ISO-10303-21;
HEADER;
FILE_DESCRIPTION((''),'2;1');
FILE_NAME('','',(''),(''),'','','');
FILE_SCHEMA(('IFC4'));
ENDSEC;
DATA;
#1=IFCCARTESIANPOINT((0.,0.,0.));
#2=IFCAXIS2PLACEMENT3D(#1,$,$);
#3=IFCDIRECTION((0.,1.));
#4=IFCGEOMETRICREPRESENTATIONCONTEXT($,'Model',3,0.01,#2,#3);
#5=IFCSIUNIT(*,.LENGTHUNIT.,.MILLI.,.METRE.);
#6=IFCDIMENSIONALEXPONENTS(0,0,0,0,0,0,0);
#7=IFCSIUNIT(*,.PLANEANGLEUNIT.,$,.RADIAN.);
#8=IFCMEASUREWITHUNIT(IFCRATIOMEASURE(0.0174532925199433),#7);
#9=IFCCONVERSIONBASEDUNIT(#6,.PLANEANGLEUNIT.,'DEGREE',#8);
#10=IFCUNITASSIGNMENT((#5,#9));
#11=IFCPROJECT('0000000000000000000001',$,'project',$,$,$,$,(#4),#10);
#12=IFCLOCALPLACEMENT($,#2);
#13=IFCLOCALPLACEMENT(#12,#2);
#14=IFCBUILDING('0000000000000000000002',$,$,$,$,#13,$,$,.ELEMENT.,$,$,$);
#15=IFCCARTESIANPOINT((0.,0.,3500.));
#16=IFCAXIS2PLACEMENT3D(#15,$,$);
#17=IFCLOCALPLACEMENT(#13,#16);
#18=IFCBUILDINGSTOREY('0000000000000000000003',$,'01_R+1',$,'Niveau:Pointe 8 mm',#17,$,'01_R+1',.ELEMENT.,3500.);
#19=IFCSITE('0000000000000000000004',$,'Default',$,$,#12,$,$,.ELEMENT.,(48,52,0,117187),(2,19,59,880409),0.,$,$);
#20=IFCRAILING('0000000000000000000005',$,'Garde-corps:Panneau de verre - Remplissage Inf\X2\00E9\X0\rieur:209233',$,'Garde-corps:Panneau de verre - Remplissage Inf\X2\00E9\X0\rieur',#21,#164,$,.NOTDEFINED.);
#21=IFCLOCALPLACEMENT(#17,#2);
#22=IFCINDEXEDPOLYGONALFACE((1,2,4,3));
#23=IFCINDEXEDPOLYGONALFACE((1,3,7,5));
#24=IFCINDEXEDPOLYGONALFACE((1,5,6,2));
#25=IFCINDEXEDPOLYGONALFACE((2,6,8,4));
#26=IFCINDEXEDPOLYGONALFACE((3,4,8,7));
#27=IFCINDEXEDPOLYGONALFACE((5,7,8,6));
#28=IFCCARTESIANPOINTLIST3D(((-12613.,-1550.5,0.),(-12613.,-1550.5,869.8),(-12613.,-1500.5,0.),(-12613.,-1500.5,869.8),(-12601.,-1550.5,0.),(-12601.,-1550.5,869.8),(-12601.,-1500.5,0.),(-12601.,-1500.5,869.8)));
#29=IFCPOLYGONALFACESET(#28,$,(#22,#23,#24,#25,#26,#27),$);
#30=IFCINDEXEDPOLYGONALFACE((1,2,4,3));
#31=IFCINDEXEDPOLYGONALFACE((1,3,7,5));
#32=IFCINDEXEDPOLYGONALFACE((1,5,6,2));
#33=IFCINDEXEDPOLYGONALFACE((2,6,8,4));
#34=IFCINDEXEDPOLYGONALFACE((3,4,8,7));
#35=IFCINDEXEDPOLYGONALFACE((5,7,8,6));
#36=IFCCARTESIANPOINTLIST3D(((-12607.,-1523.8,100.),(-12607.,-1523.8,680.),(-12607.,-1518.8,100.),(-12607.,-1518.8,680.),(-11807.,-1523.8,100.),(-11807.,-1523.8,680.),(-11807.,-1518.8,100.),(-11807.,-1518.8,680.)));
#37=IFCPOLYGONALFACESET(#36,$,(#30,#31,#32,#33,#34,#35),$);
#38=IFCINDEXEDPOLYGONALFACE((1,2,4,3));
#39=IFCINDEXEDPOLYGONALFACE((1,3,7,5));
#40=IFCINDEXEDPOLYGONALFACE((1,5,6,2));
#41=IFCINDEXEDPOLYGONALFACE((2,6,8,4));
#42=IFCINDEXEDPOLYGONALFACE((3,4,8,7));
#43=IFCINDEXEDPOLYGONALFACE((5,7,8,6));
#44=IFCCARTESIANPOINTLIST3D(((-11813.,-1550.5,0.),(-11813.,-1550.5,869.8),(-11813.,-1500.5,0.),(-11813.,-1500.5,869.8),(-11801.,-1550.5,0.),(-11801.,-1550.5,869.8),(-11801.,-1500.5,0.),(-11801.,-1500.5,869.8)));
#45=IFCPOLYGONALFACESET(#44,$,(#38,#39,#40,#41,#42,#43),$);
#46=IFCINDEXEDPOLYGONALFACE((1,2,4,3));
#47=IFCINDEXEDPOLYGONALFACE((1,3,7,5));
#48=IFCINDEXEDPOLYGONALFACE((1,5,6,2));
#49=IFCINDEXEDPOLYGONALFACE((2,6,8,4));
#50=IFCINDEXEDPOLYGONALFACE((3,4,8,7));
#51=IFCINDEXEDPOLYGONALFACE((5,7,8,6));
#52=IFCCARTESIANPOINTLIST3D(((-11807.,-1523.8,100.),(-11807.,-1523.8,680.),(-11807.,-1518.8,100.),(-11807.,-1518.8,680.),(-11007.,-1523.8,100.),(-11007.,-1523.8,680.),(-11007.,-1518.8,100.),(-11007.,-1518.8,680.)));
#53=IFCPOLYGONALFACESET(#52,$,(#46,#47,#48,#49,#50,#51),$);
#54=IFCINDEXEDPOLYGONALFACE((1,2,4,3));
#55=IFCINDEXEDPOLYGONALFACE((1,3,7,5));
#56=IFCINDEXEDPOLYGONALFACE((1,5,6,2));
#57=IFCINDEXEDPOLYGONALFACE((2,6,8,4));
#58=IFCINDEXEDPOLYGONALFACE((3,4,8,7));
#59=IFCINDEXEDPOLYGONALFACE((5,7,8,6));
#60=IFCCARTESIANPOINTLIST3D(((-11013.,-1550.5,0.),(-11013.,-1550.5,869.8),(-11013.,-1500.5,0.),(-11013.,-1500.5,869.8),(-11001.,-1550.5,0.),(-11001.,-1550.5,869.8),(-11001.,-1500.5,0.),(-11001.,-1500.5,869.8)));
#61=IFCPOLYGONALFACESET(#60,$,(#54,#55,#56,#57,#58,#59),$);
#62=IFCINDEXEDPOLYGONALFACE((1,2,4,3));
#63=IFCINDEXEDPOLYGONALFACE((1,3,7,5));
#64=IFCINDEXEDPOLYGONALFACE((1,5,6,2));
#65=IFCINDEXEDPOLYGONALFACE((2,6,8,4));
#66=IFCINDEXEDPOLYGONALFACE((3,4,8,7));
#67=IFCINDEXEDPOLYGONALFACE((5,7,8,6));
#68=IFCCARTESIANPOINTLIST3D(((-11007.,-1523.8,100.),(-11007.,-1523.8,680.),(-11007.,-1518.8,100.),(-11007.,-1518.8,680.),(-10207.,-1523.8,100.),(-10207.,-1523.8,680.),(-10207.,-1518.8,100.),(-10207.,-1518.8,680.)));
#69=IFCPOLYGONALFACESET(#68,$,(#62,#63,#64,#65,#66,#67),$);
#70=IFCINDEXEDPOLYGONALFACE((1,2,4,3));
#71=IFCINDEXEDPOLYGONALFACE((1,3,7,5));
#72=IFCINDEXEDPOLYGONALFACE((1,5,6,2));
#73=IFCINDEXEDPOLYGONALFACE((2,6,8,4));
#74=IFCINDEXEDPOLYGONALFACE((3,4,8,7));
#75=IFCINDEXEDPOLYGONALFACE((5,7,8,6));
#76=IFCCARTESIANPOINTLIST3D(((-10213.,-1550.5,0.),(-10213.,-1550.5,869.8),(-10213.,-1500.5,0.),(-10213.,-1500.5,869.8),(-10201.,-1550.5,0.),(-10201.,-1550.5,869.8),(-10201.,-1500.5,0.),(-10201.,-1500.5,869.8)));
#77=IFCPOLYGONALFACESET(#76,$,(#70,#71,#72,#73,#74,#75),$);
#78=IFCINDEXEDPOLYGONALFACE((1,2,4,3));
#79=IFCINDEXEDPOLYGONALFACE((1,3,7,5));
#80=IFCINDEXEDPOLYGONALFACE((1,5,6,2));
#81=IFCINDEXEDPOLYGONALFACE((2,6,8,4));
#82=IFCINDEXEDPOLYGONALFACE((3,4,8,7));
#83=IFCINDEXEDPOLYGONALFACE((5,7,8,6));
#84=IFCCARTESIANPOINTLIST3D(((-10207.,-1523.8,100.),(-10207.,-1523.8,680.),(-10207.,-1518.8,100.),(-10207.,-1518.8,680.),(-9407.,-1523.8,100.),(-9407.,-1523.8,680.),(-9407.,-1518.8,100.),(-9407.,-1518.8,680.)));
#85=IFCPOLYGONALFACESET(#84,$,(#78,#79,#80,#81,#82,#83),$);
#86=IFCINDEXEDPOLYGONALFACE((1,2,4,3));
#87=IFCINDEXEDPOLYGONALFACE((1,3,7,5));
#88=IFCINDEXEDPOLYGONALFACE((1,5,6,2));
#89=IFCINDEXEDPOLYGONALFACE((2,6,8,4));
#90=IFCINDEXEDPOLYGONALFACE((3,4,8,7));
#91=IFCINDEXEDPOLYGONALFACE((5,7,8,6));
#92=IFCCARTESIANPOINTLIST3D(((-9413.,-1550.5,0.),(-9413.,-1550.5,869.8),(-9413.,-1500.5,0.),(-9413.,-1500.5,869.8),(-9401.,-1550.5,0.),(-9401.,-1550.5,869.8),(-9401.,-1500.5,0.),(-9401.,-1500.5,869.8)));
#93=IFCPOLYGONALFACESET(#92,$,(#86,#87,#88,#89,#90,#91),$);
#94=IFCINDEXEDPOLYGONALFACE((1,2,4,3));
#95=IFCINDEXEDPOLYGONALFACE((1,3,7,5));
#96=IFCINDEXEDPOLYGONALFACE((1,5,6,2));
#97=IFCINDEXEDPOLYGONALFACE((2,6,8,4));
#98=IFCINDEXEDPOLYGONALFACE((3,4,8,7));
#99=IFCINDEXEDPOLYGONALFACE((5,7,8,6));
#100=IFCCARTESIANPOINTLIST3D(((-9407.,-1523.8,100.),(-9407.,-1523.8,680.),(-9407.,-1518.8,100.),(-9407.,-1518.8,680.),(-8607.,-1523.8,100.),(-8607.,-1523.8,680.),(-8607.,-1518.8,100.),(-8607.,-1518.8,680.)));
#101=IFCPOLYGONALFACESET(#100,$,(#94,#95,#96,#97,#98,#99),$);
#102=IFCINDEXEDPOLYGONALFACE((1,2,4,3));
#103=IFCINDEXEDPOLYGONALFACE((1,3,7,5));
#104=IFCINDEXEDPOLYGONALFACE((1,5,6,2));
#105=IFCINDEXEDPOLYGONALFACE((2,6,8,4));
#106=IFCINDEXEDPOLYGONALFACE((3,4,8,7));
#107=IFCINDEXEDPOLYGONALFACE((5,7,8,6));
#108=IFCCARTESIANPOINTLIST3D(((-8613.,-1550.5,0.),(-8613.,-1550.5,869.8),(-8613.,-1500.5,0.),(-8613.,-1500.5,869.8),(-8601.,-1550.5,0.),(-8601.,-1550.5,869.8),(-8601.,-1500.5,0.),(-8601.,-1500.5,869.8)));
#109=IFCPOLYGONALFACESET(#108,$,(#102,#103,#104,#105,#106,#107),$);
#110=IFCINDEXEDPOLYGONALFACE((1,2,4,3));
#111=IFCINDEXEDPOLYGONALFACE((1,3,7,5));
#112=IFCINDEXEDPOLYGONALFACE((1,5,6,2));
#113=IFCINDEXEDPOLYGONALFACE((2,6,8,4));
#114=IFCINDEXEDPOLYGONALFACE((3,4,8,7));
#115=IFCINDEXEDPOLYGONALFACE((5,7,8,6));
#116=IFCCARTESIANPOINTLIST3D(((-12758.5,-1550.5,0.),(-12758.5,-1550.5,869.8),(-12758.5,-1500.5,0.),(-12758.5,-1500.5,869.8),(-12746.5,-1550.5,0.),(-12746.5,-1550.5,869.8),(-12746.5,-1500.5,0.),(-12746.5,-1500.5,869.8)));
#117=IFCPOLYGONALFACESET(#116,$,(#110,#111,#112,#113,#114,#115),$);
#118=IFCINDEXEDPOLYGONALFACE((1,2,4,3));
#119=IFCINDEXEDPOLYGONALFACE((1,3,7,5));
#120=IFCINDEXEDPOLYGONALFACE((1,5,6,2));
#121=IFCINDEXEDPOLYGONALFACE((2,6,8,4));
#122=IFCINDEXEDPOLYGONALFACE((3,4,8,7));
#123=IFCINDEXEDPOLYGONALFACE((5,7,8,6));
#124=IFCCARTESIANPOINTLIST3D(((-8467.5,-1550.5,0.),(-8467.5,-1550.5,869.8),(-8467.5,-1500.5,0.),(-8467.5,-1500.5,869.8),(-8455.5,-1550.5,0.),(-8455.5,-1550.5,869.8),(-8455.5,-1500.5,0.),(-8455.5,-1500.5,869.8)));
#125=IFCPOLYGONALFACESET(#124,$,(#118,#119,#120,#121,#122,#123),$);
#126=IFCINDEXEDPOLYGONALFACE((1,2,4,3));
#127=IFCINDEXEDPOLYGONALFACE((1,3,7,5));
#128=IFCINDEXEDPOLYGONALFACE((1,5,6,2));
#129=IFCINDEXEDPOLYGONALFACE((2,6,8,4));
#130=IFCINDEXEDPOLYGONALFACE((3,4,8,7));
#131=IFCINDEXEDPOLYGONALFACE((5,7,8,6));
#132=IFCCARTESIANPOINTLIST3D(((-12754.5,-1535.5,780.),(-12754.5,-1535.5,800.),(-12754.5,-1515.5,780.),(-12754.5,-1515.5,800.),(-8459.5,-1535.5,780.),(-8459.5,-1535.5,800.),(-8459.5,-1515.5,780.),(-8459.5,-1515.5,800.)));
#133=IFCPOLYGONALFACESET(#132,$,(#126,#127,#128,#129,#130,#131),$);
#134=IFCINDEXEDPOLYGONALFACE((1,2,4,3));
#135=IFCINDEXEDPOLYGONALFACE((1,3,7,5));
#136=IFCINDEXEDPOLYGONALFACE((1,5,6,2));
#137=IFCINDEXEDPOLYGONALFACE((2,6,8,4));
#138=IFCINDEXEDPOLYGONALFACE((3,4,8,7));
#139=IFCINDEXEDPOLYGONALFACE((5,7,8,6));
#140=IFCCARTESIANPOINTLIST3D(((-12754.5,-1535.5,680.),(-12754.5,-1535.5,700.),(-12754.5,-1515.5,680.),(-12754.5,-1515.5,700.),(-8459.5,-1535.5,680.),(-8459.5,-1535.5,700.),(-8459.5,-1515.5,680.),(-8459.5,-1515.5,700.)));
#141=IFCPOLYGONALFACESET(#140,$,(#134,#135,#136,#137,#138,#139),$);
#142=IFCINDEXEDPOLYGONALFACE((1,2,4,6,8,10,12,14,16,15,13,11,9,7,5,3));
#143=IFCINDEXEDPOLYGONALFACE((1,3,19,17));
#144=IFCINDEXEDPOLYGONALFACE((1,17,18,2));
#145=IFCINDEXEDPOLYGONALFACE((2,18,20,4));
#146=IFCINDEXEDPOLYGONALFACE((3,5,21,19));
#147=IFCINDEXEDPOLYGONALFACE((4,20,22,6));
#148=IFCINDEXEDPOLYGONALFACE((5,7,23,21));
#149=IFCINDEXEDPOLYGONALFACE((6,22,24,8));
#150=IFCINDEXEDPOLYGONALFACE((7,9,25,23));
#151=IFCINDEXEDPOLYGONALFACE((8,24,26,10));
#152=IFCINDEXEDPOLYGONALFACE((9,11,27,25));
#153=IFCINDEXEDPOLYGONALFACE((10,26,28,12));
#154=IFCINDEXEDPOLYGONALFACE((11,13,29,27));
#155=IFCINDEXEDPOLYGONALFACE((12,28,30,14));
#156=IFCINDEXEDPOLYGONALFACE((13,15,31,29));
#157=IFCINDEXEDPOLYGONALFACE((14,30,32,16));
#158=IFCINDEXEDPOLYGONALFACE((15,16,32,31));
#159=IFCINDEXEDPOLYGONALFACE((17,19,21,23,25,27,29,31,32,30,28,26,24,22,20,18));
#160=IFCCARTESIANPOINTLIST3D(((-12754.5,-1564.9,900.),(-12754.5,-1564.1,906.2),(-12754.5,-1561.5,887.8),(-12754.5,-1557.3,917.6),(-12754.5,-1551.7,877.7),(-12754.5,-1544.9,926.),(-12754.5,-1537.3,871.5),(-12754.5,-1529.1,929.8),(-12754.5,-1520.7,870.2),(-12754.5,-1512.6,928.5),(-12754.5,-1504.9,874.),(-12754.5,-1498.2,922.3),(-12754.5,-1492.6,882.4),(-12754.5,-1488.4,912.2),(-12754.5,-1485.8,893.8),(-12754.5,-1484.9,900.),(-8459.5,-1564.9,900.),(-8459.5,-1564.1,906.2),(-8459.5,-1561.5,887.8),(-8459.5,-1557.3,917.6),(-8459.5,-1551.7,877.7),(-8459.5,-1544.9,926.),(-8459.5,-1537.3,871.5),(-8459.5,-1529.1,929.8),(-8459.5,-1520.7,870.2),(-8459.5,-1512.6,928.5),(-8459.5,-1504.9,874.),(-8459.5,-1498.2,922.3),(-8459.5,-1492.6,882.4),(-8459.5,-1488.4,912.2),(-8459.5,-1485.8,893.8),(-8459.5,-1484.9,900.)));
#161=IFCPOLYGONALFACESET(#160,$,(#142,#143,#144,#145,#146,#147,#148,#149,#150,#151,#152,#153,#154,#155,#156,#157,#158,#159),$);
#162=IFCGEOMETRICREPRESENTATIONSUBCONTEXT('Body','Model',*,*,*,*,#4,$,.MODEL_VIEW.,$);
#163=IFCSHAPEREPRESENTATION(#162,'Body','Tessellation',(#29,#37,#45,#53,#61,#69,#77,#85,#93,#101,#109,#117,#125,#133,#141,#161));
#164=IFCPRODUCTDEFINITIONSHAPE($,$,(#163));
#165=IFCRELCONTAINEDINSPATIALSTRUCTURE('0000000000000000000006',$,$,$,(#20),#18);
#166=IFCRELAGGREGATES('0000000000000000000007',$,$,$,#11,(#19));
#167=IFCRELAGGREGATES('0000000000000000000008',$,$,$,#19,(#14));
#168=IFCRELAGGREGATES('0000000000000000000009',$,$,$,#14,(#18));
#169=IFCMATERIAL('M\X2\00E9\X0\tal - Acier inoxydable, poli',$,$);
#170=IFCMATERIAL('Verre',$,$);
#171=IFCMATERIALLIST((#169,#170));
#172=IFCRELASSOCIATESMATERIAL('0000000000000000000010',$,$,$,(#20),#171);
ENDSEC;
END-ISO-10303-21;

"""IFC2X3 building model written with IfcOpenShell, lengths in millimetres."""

from ifc_helpers import new_model, entity, si_unit, converted_unit, direction, frame, frame_2d, origin, origin_2d_with_axis, place, context, subcontext, project, spatial, polyline, rectangle, outline, extrude, material, material_list, element, save


model = new_model("IFC2X3")

# Units and contexts
model_context = context("Model", 3, precision=0.01, world=origin(), true_north=direction((0.0, 1.0)))
body_context = subcontext(model_context, "Body", "Model", "MODEL_VIEW")
ifc_project = project(units=[si_unit("LENGTHUNIT", "METRE", prefix="MILLI"), converted_unit("PLANEANGLEUNIT", "DEGREE", entity("IfcRatioMeasure", 0.0174532925199433), si_unit("PLANEANGLEUNIT", "RADIAN"), dimensions=[0, 0, 0, 0, 0, 0, 0])], contexts=[model_context])

# Site, building, storey
site_placement = place(None, origin())
site = spatial("IfcSite", under=ifc_project, at=site_placement, Name="Default", CompositionType="ELEMENT", RefLatitude=(48, 52, 0, 117187), RefLongitude=(2, 19, 59, 880409), RefElevation=0.0)
building_placement = place(site_placement, origin())
building = spatial("IfcBuilding", under=site, at=building_placement, CompositionType="ELEMENT")
storey_placement = place(building_placement, frame((0.0, 0.0, 3500.0)))
storey = spatial("IfcBuildingStorey", under=building, at=storey_placement, Name="01_R+1", ObjectType="Niveau:Pointe 8 mm", LongName="01_R+1", CompositionType="ELEMENT", Elevation=3500.0)

# Railing
ifc_material_1 = material(Name="Métal - Acier inoxydable, poli")
ifc_material_2 = material(Name="Verre")
ifc_material_list_1 = material_list([ifc_material_1, ifc_material_2])
railing_1_placement = place(storey_placement, origin())
element("IfcRailing", 1, at=railing_1_placement, inside=storey, material=ifc_material_list_1, Name="Garde-corps:Panneau de verre - Remplissage Inférieur:209233", ObjectType="Garde-corps:Panneau de verre - Remplissage Inférieur", PredefinedType="NOTDEFINED", context=body_context, shape_type="SweptSolid", body=[
    extrude(rectangle(XDim=50.0, YDim=12.0, at=frame_2d((0.0, 0.0), x_axis=(1.0, 0.0))), frame((-12607.0, -1525.5, 0.0), z_axis=(0.0, 0.0, 1.0), x_axis=(0.0, 1.0, 0.0)), (0.0, 0.0, 1.0), 869.8),
    extrude(rectangle(XDim=5.0, YDim=800.0, at=frame_2d((0.0, 0.0), x_axis=(1.0, 0.0))), frame((-12207.0, -1521.3, 100.0), z_axis=(0.0, 0.0, 1.0), x_axis=(0.0, 1.0, 0.0)), (0.0, 0.0, 1.0), 580.0),
    extrude(rectangle(XDim=50.0, YDim=12.0, at=frame_2d((0.0, 0.0), x_axis=(1.0, 0.0))), frame((-11807.0, -1525.5, 0.0), z_axis=(0.0, 0.0, 1.0), x_axis=(0.0, 1.0, 0.0)), (0.0, 0.0, 1.0), 869.8),
    extrude(rectangle(XDim=5.0, YDim=800.0, at=frame_2d((0.0, 0.0), x_axis=(1.0, 0.0))), frame((-11407.0, -1521.3, 100.0), z_axis=(0.0, 0.0, 1.0), x_axis=(0.0, 1.0, 0.0)), (0.0, 0.0, 1.0), 580.0),
    extrude(rectangle(XDim=50.0, YDim=12.0, at=frame_2d((0.0, 0.0), x_axis=(1.0, 0.0))), frame((-11007.0, -1525.5, 0.0), z_axis=(0.0, 0.0, 1.0), x_axis=(0.0, 1.0, 0.0)), (0.0, 0.0, 1.0), 869.8),
    extrude(rectangle(XDim=5.0, YDim=800.0, at=frame_2d((0.0, 0.0), x_axis=(1.0, 0.0))), frame((-10607.0, -1521.3, 100.0), z_axis=(0.0, 0.0, 1.0), x_axis=(0.0, 1.0, 0.0)), (0.0, 0.0, 1.0), 580.0),
    extrude(rectangle(XDim=50.0, YDim=12.0, at=frame_2d((0.0, 0.0), x_axis=(1.0, 0.0))), frame((-10207.0, -1525.5, 0.0), z_axis=(0.0, 0.0, 1.0), x_axis=(0.0, 1.0, 0.0)), (0.0, 0.0, 1.0), 869.8),
    extrude(rectangle(XDim=5.0, YDim=800.0, at=frame_2d((0.0, 0.0), x_axis=(1.0, 0.0))), frame((-9807.0, -1521.3, 100.0), z_axis=(0.0, 0.0, 1.0), x_axis=(0.0, 1.0, 0.0)), (0.0, 0.0, 1.0), 580.0),
    extrude(rectangle(XDim=50.0, YDim=12.0, at=frame_2d((0.0, 0.0), x_axis=(1.0, 0.0))), frame((-9407.0, -1525.5, 0.0), z_axis=(0.0, 0.0, 1.0), x_axis=(0.0, 1.0, 0.0)), (0.0, 0.0, 1.0), 869.8),
    extrude(rectangle(XDim=5.0, YDim=800.0, at=origin_2d_with_axis()), frame((-9007.0, -1521.3, 100.0), z_axis=(0.0, 0.0, 1.0), x_axis=(0.0, 1.0, 0.0)), (0.0, 0.0, 1.0), 580.0),
    extrude(rectangle(XDim=50.0, YDim=12.0, at=frame_2d((0.0, 0.0), x_axis=(1.0, 0.0))), frame((-8607.0, -1525.5, 0.0), z_axis=(0.0, 0.0, 1.0), x_axis=(0.0, 1.0, 0.0)), (0.0, 0.0, 1.0), 869.8),
    extrude(rectangle(XDim=50.0, YDim=12.0, at=frame_2d((0.0, 0.0), x_axis=(1.0, 0.0))), frame((-12752.5, -1525.5, 0.0), z_axis=(0.0, 0.0, 1.0), x_axis=(0.0, 1.0, 0.0)), (0.0, 0.0, 1.0), 869.8),
    extrude(rectangle(XDim=50.0, YDim=12.0, at=frame_2d((0.0, 0.0), x_axis=(1.0, 0.0))), frame((-8461.5, -1525.5, 0.0), z_axis=(0.0, 0.0, 1.0), x_axis=(0.0, 1.0, 0.0)), (0.0, 0.0, 1.0), 869.8),
    extrude(rectangle(XDim=4295.0, YDim=20.0, at=origin_2d_with_axis()), frame((-10607.0, -1525.5, 780.0), z_axis=(0.0, 0.0, 1.0), x_axis=(-1.0, 0.0, 0.0)), (0.0, 0.0, 1.0), 20.0),
    extrude(rectangle(XDim=4295.0, YDim=20.0, at=origin_2d_with_axis()), frame((-10607.0, -1525.5, 680.0), z_axis=(0.0, 0.0, 1.0), x_axis=(-1.0, 0.0, 0.0)), (0.0, 0.0, 1.0), 20.0),
    extrude(outline(polyline([(-10.9, -38.5), (1.8, -38.5), (14.2, -31.8), (24.1, -19.7), (29.8, -4.1), (30.4, 12.2), (25.8, 26.3), (16.7, 35.9), (10.9, 38.5), (-1.8, 38.5), (-14.2, 31.8), (-24.1, 19.7), (-29.8, 4.1), (-30.4, -12.2), (-25.8, -26.3), (-16.7, -35.9), (-10.9, -38.5)])), frame((-12754.5, -1524.9, 900.0), z_axis=(1.0, 0.0, 0.0), x_axis=(0.0, -0.27267, 0.962108)), (0.0, 0.0, 1.0), 4295.0),
])

save(model, "model.ifc")
